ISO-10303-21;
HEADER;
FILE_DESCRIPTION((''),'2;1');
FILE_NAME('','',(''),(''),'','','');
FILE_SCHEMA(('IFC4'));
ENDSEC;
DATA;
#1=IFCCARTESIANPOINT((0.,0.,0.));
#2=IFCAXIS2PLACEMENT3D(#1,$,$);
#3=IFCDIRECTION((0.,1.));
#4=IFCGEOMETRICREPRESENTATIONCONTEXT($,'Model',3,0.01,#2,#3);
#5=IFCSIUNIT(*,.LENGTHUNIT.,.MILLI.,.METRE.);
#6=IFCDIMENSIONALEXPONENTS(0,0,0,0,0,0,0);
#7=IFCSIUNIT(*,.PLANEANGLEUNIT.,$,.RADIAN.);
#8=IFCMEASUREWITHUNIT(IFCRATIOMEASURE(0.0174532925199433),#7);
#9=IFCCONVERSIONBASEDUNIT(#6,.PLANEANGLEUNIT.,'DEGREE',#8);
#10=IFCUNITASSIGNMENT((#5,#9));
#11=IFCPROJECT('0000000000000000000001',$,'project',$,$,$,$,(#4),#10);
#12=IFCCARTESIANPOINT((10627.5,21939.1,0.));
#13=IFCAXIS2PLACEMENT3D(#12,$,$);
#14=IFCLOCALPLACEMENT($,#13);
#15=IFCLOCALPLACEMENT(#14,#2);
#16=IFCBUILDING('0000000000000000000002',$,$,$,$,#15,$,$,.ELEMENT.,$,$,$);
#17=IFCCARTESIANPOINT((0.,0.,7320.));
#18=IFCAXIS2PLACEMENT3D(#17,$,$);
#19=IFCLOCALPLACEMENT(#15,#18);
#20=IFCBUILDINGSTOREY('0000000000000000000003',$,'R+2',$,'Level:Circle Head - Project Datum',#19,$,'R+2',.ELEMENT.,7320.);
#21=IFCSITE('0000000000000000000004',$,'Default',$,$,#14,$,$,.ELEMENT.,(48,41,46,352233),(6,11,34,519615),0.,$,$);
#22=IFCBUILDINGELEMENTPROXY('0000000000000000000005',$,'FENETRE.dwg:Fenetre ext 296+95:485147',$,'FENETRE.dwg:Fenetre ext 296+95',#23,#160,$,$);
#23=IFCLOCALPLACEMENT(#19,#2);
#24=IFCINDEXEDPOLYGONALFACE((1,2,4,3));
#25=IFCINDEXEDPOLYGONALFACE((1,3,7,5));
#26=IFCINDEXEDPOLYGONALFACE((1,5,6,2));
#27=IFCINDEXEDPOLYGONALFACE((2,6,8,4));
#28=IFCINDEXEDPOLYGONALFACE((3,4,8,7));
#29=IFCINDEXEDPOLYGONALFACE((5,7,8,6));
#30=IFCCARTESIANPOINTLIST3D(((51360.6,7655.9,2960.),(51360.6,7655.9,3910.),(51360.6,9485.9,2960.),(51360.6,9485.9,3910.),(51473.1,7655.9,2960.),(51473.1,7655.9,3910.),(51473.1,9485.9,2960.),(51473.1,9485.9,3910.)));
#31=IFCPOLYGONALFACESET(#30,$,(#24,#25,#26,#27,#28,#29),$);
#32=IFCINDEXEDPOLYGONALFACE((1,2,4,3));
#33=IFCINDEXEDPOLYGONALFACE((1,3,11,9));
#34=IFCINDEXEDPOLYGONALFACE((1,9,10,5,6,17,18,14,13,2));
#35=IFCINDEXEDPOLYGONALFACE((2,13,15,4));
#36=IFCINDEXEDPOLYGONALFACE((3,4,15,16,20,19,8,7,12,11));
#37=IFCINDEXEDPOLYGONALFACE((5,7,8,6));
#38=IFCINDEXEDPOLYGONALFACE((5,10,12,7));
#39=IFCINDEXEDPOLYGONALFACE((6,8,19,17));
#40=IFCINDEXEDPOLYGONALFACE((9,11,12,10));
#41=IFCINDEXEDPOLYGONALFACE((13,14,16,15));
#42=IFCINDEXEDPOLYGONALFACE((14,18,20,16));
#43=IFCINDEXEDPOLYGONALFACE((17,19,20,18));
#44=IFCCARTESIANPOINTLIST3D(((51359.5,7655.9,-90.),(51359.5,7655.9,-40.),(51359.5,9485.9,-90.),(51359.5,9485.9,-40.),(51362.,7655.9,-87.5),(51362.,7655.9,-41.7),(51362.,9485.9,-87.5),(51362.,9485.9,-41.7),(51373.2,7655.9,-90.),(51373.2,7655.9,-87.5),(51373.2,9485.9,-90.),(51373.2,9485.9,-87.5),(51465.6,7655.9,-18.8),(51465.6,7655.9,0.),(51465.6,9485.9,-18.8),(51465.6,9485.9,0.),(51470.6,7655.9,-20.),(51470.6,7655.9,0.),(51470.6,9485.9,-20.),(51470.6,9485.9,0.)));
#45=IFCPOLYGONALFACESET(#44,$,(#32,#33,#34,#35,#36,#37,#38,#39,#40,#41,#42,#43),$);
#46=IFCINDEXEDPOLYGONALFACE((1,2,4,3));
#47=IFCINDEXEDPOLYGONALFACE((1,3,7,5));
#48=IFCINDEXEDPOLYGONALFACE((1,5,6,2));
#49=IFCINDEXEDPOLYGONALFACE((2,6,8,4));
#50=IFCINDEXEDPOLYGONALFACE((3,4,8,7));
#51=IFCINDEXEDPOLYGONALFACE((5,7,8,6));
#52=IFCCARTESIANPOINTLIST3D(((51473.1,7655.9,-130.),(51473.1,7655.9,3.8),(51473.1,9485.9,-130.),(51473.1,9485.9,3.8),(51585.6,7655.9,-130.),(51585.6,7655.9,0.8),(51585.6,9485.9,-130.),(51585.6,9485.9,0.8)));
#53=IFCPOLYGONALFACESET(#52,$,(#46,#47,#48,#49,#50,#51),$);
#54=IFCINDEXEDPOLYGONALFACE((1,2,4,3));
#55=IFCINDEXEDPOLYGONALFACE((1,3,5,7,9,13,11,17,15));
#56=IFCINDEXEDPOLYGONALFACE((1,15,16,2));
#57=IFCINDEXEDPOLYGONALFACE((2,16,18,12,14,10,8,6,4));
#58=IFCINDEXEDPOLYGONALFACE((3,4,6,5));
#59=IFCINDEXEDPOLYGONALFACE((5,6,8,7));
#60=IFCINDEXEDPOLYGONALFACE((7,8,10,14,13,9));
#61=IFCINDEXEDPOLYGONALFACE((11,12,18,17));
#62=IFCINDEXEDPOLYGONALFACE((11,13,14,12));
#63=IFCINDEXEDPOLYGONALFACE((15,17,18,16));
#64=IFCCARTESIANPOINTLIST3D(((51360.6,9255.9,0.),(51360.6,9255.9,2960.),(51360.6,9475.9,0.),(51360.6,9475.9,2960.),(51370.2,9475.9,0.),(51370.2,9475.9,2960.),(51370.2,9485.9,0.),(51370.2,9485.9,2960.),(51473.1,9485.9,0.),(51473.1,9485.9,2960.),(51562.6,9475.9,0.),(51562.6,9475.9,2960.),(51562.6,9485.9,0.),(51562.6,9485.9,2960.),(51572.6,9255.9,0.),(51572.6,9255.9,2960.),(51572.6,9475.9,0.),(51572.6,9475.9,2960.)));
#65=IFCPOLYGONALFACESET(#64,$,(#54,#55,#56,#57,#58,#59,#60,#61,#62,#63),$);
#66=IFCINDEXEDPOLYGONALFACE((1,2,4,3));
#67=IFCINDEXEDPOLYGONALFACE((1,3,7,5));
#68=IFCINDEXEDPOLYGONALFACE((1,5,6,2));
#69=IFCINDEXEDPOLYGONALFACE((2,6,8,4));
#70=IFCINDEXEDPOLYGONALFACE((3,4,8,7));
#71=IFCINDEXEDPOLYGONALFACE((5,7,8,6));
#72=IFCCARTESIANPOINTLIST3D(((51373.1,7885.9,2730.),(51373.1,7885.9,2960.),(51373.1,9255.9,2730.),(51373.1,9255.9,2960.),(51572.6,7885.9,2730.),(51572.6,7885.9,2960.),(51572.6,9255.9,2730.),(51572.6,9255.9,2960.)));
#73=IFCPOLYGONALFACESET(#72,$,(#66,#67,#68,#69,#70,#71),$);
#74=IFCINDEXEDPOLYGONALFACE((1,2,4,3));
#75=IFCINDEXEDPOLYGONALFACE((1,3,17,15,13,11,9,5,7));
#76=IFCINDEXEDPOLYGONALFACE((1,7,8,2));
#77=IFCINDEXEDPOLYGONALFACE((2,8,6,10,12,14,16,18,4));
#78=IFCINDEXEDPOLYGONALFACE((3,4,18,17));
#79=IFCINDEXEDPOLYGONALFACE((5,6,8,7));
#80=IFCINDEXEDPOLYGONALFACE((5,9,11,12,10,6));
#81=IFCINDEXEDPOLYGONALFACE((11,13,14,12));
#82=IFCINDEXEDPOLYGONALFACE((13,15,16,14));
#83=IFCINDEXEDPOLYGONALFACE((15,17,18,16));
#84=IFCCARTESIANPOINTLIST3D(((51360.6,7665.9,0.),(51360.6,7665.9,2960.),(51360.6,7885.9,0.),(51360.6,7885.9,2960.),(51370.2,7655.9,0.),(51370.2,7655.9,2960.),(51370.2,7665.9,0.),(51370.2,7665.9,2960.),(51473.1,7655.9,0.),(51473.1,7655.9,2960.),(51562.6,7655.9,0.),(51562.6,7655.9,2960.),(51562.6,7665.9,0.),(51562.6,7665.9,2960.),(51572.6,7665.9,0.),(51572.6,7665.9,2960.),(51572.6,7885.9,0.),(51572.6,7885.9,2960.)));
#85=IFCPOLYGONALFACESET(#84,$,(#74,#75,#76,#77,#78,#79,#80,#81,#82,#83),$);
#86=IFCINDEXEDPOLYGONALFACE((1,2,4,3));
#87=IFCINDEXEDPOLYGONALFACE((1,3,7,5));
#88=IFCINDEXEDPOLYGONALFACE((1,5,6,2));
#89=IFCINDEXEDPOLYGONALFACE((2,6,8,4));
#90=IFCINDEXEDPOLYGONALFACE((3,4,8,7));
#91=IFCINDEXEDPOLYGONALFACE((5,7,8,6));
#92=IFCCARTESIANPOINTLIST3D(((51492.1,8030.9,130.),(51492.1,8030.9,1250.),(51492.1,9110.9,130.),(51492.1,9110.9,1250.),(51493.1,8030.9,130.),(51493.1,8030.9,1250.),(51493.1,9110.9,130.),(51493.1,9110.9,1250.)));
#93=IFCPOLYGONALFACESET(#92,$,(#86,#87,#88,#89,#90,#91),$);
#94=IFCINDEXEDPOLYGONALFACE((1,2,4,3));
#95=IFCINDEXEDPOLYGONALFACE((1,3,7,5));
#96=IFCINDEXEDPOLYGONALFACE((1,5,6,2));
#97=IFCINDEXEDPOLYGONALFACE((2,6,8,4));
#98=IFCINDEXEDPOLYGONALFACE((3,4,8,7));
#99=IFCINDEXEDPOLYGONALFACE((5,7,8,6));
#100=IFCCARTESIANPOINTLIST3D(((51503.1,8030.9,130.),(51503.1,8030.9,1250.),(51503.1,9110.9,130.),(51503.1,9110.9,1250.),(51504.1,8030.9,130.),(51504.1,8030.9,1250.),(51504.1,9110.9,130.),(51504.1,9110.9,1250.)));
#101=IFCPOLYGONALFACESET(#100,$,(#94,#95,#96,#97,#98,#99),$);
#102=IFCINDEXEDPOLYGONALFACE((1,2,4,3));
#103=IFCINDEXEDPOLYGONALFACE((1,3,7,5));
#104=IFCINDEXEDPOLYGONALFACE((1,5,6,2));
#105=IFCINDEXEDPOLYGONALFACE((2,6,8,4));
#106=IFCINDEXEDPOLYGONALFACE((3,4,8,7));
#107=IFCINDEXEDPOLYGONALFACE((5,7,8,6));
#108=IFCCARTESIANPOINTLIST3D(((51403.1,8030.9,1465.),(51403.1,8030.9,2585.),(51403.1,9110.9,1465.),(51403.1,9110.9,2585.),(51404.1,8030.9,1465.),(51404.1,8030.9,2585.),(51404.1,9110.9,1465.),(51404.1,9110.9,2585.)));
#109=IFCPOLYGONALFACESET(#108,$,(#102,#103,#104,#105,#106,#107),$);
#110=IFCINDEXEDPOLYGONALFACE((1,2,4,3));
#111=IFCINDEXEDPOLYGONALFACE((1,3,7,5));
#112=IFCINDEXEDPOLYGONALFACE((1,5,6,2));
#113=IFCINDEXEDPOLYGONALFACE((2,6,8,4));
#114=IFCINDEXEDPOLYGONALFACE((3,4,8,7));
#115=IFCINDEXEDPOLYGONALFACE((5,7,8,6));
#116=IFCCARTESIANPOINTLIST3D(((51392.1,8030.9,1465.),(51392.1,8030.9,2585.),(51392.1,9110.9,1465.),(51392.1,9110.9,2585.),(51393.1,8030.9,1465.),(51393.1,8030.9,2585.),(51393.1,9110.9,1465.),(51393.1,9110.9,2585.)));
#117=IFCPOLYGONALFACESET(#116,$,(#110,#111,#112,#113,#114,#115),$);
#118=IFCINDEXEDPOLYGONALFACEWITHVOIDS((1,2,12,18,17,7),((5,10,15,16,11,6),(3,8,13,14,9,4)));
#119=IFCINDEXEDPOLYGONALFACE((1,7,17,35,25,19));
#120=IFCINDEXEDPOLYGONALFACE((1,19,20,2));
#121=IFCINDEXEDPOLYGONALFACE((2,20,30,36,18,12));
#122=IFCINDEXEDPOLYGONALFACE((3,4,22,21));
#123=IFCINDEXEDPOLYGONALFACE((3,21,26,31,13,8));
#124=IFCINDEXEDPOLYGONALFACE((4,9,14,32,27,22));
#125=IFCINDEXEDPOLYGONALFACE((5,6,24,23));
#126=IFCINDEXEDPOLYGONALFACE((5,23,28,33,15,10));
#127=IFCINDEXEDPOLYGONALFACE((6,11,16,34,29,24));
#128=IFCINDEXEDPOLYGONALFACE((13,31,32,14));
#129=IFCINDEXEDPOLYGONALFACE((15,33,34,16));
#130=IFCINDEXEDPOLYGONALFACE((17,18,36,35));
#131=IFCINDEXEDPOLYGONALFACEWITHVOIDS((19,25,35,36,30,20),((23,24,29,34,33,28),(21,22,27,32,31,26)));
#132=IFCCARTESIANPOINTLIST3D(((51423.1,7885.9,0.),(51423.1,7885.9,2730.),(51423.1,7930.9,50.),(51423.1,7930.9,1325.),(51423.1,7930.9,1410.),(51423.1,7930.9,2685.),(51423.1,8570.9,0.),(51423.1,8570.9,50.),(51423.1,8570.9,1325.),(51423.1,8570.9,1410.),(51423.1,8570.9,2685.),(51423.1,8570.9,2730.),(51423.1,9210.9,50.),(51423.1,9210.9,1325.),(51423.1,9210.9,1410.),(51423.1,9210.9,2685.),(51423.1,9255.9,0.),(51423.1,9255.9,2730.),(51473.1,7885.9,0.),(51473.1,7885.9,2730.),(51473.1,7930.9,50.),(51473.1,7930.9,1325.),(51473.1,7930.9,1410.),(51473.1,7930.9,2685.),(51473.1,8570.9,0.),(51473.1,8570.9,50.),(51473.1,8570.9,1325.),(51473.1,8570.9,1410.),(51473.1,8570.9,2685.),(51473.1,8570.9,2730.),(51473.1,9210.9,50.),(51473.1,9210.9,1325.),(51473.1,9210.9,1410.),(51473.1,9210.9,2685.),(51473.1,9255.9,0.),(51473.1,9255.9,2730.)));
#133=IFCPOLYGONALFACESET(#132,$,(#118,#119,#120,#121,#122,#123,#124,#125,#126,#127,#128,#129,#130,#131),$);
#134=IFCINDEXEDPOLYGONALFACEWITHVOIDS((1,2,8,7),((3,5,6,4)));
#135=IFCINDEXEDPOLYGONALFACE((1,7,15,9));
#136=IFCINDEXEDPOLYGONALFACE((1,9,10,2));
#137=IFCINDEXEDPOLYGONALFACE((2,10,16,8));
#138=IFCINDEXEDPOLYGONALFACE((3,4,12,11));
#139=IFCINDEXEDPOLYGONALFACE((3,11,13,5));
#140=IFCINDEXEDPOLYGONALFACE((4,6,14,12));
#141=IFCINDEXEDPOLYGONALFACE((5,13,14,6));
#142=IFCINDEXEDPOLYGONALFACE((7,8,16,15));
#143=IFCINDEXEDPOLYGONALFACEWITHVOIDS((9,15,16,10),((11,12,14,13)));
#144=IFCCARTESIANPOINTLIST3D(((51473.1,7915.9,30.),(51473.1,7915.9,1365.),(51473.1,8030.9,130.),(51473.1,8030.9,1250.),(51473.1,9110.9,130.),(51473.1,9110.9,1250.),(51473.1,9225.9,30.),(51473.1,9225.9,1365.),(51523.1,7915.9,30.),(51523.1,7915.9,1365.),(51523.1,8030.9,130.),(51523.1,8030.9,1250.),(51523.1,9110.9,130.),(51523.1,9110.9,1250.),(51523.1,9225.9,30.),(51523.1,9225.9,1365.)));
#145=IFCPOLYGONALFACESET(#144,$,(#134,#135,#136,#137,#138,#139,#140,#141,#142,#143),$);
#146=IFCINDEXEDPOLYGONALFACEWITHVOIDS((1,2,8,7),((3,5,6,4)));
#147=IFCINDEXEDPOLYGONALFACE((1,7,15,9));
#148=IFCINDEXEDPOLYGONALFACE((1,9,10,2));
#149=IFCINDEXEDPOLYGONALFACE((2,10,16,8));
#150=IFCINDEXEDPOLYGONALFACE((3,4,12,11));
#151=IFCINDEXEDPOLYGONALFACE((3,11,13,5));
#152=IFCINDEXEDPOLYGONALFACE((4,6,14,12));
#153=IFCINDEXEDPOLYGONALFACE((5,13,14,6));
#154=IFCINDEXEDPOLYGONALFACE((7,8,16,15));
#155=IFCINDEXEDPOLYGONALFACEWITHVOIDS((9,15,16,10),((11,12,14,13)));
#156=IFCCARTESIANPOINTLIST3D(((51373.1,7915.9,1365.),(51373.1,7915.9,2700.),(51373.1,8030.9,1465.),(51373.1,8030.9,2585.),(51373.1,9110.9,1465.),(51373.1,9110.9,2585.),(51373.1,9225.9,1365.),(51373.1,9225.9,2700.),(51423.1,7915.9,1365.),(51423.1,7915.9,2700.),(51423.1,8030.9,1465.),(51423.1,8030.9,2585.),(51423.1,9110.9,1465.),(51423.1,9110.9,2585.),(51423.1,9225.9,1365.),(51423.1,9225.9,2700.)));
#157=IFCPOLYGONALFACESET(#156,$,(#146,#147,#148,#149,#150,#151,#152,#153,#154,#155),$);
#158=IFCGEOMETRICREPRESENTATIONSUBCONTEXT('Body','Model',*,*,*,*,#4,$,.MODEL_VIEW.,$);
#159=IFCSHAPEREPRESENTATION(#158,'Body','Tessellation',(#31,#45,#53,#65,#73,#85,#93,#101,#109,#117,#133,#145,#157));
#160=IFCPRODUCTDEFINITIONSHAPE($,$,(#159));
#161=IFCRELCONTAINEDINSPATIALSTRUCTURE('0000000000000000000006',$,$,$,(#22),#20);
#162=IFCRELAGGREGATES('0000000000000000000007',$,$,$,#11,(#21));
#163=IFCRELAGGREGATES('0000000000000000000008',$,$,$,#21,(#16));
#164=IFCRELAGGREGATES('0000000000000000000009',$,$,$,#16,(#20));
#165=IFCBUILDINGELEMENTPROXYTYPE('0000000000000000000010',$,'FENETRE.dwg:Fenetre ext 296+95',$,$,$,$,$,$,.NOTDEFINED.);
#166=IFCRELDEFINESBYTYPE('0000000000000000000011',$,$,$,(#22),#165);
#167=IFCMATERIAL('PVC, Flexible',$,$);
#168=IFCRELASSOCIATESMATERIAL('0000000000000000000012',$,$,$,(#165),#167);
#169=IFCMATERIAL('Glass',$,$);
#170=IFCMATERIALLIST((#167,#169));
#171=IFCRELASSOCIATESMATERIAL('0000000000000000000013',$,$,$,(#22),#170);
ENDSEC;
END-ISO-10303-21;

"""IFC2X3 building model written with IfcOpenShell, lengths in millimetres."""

from ifc_helpers import new_model, entity, si_unit, converted_unit, direction, frame, frame_2d, origin, origin_2d_with_axis, place, context, subcontext, project, spatial, polyline, rectangle, outline, extrude, source, transform, mapped, material, material_list, type_object, type_shapes, element, save


model = new_model("IFC2X3")

# Units and contexts
model_context = context("Model", 3, precision=0.01, world=origin(), true_north=direction((0.0, 1.0)))
body_context = subcontext(model_context, "Body", "Model", "MODEL_VIEW")
ifc_project = project(units=[si_unit("LENGTHUNIT", "METRE", prefix="MILLI"), converted_unit("PLANEANGLEUNIT", "DEGREE", entity("IfcRatioMeasure", 0.0174532925199433), si_unit("PLANEANGLEUNIT", "RADIAN"), dimensions=[0, 0, 0, 0, 0, 0, 0])], contexts=[model_context])

# Site, building, storey
site_placement = place(None, frame((10627.5, 21939.1, 0.0)))
site = spatial("IfcSite", under=ifc_project, at=site_placement, Name="Default", CompositionType="ELEMENT", RefLatitude=(48, 41, 46, 352233), RefLongitude=(6, 11, 34, 519615), RefElevation=0.0)
building_placement = place(site_placement, origin())
building = spatial("IfcBuilding", under=site, at=building_placement, CompositionType="ELEMENT")
storey_placement = place(building_placement, frame((0.0, 0.0, 7320.0)))
storey = spatial("IfcBuildingStorey", under=building, at=storey_placement, Name="R+2", ObjectType="Level:Circle Head - Project Datum", LongName="R+2", CompositionType="ELEMENT", Elevation=7320.0)

# Building element proxy
ifc_material_1 = material(Name="PVC, Flexible")
ifc_material_2 = material(Name="Glass")
building_element_proxy_type_1 = type_object("IfcBuildingElementProxyType", Name="FENETRE.dwg:Fenetre ext 296+95", PredefinedType="NOTDEFINED", material=ifc_material_1)
shared_shape_1 = source(origin(), body_context, "Body", "SweptSolid", [
    extrude(rectangle(XDim=1830.0, YDim=112.5, at=origin_2d_with_axis()), frame((-10.4, 56.3, 2960.0), z_axis=(0.0, 0.0, 1.0), x_axis=(-1.0, 0.0, 0.0)), (0.0, 0.0, 1.0), 950.0),
    extrude(outline(polyline([(-68.6, -14.4), (-72.5, -34.0), (-67.6, -35.0), (-63.9, -16.6), (44.3, -16.6), (54.1, 32.5), (40.6, 35.2), (40.1, 32.7), (51.2, 30.5), (42.2, -14.4), (-68.6, -14.4)])), frame((-925.4, 66.9, -47.5), z_axis=(-1.0, 0.0, 0.0), x_axis=(0.0, 0.980599, -0.196027)), (0.0, 0.0, -1.0), 1830.0),
    extrude(outline(polyline([(-64.7, -56.3), (66.2, -56.3), (66.2, 56.3), (-67.7, 56.3), (-64.7, -56.3)])), frame((-925.4, -56.3, -63.8), z_axis=(1.0, 0.0, 0.0), x_axis=(0.0, 0.0, -1.0)), (0.0, 0.0, 1.0), 1830.0),
    extrude(outline(polyline([(-55.6, 97.0), (-55.6, -5.9), (-55.6, -95.4), (-45.6, -95.4), (-45.6, -105.4), (174.4, -105.4), (174.4, 106.6), (-45.6, 106.6), (-45.6, 97.0), (-55.6, 97.0)])), frame((849.0, 5.9, 0.0), z_axis=(0.0, 0.0, -1.0), x_axis=(-1.0, 0.0, 0.0)), (0.0, 0.0, -1.0), 2960.0),
    extrude(rectangle(XDim=199.5, YDim=1370.0, at=origin_2d_with_axis()), frame((-10.4, 0.3, 2730.0), z_axis=(0.0, 0.0, 1.0), x_axis=(0.0, 1.0, 0.0)), (0.0, 0.0, 1.0), 230.0),
    extrude(outline(polyline([(-97.0, -55.6), (5.9, -55.6), (95.4, -55.6), (95.4, -45.6), (105.4, -45.6), (105.4, 174.4), (-106.6, 174.4), (-106.6, -45.6), (-97.0, -45.6), (-97.0, -55.6)])), frame((-869.9, 5.9, 0.0), z_axis=(0.0, 0.0, 1.0), x_axis=(0.0, -1.0, 0.0)), (0.0, 0.0, 1.0), 2960.0),
    extrude(rectangle(XDim=1.0, YDim=1080.0, at=origin_2d_with_axis()), frame((-10.4, -19.5, 130.0), z_axis=(0.0, 0.0, 1.0), x_axis=(0.0, 1.0, 0.0)), (0.0, 0.0, 1.0), 1120.0),
    extrude(rectangle(XDim=1.0, YDim=1080.0, at=frame_2d((0.0, 0.0), x_axis=(1.0, 0.0))), frame((-10.4, -30.5, 130.0), z_axis=(0.0, 0.0, 1.0), x_axis=(0.0, 1.0, 0.0)), (0.0, 0.0, 1.0), 1120.0),
    extrude(rectangle(XDim=1.0, YDim=1080.0, at=frame_2d((0.0, 0.0), x_axis=(1.0, 0.0))), frame((-10.4, 69.5, 1465.0), z_axis=(0.0, 0.0, 1.0), x_axis=(0.0, 1.0, 0.0)), (0.0, 0.0, 1.0), 1120.0),
    extrude(rectangle(XDim=1.0, YDim=1080.0, at=frame_2d((0.0, 0.0), x_axis=(1.0, 0.0))), frame((-10.4, 80.5, 1465.0), z_axis=(0.0, 0.0, 1.0), x_axis=(0.0, 1.0, 0.0)), (0.0, 0.0, 1.0), 1120.0),
    extrude(outline(polyline([(-685.0, -1365.0), (0.0, -1365.0), (685.0, -1365.0), (685.0, 1365.0), (0.0, 1365.0), (-685.0, 1365.0), (-685.0, -1365.0)]), holes=[polyline([(-640.0, -1320.0), (-640.0, -45.0), (0.0, -45.0), (640.0, -45.0), (640.0, -1320.0), (0.0, -1320.0), (-640.0, -1320.0)]), polyline([(-640.0, 40.0), (-640.0, 1315.0), (0.0, 1315.0), (640.0, 1315.0), (640.0, 40.0), (0.0, 40.0), (-640.0, 40.0)])]), frame((-10.4, 0.0, 1365.0), z_axis=(0.0, 1.0, 0.0), x_axis=(1.0, 0.0, 0.0)), (0.0, 0.0, 1.0), 50.0),
    extrude(outline(polyline([(-655.0, -667.5), (655.0, -667.5), (655.0, 667.5), (-655.0, 667.5), (-655.0, -667.5)]), holes=[polyline([(-540.0, 552.5), (540.0, 552.5), (540.0, -567.5), (-540.0, -567.5), (-540.0, 552.5)])]), frame((-10.4, -50.0, 697.5), z_axis=(0.0, 1.0, 0.0), x_axis=(-1.0, 0.0, 0.0)), (0.0, 0.0, 1.0), 50.0),
    extrude(outline(polyline([(-655.0, -667.5), (655.0, -667.5), (655.0, 667.5), (-655.0, 667.5), (-655.0, -667.5)]), holes=[polyline([(-540.0, 552.5), (540.0, 552.5), (540.0, -567.5), (-540.0, -567.5), (-540.0, 552.5)])]), frame((-10.4, 50.0, 2032.5), z_axis=(0.0, 1.0, 0.0), x_axis=(-1.0, 0.0, 0.0)), (0.0, 0.0, 1.0), 50.0),
])
type_shapes(building_element_proxy_type_1, [shared_shape_1])
ifc_material_list_1 = material_list([ifc_material_1, ifc_material_2])
proxy_1_placement = place(storey_placement, frame((51473.1, 8581.3, 0.0), z_axis=(0.0, 0.0, 1.0), x_axis=(0.0, 1.0, 0.0)))
element("IfcBuildingElementProxy", 1, at=proxy_1_placement, inside=storey, type_object=building_element_proxy_type_1, material=ifc_material_list_1, Name="FENETRE.dwg:Fenetre ext 296+95:485147", ObjectType="FENETRE.dwg:Fenetre ext 296+95", context=body_context, shape_type="MappedRepresentation", body=[
    mapped(shared_shape_1, transform((0.0, 0.0, 0.0), scale=1.0)),
])

save(model, "model.ifc")
